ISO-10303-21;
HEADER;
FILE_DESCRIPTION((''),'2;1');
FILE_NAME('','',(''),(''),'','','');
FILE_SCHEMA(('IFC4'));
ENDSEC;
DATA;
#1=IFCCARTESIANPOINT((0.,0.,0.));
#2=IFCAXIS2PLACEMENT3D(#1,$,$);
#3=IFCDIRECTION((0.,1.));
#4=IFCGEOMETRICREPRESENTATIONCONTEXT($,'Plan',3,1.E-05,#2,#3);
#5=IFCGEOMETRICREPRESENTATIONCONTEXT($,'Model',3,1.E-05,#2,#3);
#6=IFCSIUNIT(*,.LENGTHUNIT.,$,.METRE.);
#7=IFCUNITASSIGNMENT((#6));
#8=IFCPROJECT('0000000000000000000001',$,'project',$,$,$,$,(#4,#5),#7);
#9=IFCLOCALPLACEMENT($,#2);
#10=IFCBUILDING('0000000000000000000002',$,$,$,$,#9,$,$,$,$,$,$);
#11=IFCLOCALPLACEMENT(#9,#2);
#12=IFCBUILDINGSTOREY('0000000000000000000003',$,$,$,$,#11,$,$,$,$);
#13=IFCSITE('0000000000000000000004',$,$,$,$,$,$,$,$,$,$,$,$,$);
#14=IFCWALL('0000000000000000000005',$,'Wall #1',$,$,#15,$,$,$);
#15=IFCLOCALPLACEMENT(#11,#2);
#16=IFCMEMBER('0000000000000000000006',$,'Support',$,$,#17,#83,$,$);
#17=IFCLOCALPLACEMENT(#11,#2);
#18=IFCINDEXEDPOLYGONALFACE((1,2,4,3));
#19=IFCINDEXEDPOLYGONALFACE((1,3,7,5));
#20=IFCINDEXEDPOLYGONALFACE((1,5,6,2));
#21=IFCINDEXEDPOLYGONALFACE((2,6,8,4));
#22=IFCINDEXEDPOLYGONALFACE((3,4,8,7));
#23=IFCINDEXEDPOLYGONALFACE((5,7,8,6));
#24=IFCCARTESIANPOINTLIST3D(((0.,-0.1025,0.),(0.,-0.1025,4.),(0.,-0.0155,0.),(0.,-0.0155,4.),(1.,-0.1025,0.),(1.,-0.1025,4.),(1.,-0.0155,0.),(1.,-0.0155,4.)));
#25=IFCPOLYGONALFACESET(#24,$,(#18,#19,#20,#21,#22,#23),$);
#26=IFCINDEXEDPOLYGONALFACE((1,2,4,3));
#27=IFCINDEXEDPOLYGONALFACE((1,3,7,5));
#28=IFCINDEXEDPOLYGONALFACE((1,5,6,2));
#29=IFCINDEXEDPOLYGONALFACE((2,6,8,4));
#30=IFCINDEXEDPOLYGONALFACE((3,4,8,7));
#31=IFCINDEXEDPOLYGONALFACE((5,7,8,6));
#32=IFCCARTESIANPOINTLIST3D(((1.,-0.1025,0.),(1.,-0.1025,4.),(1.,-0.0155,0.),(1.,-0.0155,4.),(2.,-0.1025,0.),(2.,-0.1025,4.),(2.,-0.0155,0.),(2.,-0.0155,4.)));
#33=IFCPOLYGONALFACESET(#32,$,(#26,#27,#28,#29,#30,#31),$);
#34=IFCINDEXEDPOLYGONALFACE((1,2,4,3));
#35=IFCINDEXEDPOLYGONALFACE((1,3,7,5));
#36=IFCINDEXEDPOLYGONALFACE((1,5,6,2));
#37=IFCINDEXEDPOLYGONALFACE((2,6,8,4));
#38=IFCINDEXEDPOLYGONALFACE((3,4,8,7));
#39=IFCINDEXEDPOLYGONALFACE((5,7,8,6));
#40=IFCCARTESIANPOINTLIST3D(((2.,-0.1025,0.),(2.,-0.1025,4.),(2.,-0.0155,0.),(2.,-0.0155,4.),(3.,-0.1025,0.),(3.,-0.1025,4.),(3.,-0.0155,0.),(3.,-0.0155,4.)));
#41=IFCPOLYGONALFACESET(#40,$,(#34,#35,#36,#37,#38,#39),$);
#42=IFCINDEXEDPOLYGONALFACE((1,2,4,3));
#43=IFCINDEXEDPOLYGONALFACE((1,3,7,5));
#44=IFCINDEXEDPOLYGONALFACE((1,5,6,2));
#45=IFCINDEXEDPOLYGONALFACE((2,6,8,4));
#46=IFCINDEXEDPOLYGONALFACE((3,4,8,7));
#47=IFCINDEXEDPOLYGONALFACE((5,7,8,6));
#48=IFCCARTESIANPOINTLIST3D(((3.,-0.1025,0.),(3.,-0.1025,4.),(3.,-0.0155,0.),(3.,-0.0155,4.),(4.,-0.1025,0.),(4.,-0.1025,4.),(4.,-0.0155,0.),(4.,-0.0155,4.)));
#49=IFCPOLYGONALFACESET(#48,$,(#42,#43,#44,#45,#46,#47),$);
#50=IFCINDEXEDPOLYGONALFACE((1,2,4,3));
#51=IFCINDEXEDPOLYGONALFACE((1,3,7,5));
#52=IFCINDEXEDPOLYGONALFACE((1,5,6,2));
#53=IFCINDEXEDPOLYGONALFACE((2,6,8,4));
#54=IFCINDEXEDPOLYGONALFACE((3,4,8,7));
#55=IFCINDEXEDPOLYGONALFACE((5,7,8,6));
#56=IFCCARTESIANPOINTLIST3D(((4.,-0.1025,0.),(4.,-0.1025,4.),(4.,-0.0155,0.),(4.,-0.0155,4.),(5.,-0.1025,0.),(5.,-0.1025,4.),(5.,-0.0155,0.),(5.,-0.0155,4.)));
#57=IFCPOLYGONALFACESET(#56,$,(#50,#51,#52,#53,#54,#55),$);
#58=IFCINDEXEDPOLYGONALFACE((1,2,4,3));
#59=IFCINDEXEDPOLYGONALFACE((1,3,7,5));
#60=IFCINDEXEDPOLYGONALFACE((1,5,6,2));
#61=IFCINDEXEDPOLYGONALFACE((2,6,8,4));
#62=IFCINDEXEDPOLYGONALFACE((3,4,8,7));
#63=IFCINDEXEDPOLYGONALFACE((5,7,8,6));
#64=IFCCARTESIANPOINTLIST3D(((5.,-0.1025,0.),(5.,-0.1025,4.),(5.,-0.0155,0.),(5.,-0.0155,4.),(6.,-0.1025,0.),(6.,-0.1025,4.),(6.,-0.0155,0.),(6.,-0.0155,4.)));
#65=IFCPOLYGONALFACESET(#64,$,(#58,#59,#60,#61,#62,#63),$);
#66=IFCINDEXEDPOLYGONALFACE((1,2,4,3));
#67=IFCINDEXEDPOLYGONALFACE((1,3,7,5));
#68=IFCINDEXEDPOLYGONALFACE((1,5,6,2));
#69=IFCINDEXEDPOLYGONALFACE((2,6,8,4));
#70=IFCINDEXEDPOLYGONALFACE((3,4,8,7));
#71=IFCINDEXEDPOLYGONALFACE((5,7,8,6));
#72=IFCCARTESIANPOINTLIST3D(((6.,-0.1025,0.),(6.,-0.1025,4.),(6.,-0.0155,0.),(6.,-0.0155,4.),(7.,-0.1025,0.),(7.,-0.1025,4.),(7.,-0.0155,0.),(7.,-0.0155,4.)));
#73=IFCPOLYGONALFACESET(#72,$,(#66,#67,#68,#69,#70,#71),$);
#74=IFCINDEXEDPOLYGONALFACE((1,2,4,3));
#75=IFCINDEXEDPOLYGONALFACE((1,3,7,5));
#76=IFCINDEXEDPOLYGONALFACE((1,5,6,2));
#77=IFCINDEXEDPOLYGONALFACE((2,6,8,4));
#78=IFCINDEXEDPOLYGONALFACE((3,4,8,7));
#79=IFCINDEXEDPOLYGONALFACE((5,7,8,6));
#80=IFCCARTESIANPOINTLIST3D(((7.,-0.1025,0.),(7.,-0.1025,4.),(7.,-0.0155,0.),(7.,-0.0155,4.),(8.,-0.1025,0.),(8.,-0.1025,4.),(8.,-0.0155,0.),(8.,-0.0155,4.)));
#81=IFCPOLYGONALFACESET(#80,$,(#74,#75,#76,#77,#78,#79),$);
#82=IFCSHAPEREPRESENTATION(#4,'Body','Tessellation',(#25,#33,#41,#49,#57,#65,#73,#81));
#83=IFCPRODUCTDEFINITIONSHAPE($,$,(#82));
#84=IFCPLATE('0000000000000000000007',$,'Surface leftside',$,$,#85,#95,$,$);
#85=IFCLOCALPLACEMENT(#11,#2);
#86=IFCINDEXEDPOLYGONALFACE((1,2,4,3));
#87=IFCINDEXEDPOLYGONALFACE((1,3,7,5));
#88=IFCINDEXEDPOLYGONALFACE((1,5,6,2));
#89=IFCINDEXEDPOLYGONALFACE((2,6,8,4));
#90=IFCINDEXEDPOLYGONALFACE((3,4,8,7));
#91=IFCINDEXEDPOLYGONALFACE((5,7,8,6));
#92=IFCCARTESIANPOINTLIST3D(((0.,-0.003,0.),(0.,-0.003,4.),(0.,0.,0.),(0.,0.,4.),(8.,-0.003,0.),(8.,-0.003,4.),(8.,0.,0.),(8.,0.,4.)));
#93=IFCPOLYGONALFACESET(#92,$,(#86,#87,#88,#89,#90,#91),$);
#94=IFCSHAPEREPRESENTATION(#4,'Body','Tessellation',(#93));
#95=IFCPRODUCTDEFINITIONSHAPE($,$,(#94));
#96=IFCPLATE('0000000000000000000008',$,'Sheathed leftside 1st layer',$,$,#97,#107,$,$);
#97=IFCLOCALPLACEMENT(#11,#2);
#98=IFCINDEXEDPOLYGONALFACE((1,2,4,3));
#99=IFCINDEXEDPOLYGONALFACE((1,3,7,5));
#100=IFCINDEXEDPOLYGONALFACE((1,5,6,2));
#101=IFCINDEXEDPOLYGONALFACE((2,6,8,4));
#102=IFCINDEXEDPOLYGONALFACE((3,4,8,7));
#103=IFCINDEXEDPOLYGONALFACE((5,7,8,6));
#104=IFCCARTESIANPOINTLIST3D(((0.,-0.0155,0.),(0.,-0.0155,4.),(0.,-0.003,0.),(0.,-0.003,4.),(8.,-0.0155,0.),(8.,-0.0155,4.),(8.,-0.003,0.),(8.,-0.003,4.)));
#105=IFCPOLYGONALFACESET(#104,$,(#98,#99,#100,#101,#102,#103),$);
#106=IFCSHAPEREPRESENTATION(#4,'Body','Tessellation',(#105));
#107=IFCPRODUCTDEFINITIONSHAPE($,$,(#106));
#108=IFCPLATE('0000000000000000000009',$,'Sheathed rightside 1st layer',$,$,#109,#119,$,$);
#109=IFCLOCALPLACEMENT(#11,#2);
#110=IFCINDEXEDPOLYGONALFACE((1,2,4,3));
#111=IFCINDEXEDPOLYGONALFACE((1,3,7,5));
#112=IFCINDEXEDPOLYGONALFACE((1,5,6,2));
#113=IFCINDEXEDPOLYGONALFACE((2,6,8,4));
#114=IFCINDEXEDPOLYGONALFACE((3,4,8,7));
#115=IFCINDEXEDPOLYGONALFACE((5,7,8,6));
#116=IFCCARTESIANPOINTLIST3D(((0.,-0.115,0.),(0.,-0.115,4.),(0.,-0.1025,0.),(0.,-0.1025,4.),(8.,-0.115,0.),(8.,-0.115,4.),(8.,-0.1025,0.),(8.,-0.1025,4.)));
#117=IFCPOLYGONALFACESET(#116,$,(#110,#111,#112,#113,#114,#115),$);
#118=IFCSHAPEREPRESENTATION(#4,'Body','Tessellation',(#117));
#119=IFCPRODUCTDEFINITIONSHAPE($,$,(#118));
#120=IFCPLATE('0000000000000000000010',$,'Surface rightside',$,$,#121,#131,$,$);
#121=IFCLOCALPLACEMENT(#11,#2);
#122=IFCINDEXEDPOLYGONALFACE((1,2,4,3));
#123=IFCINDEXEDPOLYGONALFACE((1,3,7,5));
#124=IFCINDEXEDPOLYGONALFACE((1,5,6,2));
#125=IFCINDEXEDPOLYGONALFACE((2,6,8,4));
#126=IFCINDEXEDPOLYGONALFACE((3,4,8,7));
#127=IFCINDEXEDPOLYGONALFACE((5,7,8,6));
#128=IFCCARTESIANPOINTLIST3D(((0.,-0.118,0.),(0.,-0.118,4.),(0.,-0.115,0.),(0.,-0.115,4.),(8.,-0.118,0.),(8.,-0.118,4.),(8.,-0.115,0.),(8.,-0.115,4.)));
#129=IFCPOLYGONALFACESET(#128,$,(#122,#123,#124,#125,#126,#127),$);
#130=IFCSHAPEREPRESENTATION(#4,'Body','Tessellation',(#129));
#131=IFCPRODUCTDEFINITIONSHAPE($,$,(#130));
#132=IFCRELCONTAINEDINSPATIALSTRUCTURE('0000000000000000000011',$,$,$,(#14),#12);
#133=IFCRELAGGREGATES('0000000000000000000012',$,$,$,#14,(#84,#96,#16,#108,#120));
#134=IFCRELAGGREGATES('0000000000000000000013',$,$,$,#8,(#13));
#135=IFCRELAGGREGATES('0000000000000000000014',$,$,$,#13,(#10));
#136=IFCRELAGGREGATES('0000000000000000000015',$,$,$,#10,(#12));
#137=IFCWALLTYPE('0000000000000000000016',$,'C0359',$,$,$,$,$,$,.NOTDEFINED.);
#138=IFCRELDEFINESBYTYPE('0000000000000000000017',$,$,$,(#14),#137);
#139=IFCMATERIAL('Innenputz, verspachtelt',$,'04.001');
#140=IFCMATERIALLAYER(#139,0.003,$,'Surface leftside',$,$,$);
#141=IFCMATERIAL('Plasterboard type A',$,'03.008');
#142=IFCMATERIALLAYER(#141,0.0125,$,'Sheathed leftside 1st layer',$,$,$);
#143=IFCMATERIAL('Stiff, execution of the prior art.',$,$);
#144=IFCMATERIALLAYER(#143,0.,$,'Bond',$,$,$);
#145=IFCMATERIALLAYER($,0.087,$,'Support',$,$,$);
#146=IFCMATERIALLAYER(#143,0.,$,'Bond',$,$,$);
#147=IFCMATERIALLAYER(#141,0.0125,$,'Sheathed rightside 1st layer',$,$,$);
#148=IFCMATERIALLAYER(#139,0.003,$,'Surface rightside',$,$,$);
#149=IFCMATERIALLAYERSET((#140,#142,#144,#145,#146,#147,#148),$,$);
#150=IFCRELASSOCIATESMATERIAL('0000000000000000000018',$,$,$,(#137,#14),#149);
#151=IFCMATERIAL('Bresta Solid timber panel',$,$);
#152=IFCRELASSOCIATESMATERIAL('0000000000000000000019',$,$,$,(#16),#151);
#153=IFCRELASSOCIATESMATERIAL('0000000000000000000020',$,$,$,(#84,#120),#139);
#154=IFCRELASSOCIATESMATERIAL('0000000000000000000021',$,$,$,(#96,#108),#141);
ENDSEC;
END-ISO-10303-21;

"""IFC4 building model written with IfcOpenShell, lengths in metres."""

from ifc_helpers import new_model, si_unit, direction, frame, frame_2d, origin, origin_with_axes, place, context, project, spatial, rectangle, extrude, material, layer, layer_set, type_object, element, aggregate, save


model = new_model("IFC4")

# Units and contexts
plan_context = context("Plan", 3, precision=1e-05, world=origin(), true_north=direction((0.0, 1.0)))
model_context = context("Model", 3, precision=1e-05, world=origin(), true_north=direction((0.0, 1.0)))
ifc_project = project(units=[si_unit("LENGTHUNIT", "METRE")], contexts=[plan_context, model_context])

# Site, building, storey
site = spatial("IfcSite", under=ifc_project)
building_placement = place(None, origin())
building = spatial("IfcBuilding", under=site, at=building_placement)
storey_placement = place(building_placement, origin())
storey = spatial("IfcBuildingStorey", under=building, at=storey_placement)

# Wall, member, plates
ifc_material_1 = material(Name="Innenputz, verspachtelt", Category="04.001")
ifc_layer_1 = layer(ifc_material_1, 0.003, Name="Surface leftside")
ifc_material_2 = material(Name="Plasterboard type A", Category="03.008")
ifc_layer_2 = layer(ifc_material_2, 0.0125, Name="Sheathed leftside 1st layer")
ifc_material_3 = material(Name="Stiff, execution of the prior art.")
ifc_layer_3 = layer(ifc_material_3, 0.0, Name="Bond")
ifc_layer_4 = layer(None, 0.087, Name="Support")
ifc_layer_5 = layer(ifc_material_3, 0.0, Name="Bond")
ifc_layer_6 = layer(ifc_material_2, 0.0125, Name="Sheathed rightside 1st layer")
ifc_layer_7 = layer(ifc_material_1, 0.003, Name="Surface rightside")
ifc_layer_set = layer_set([ifc_layer_1, ifc_layer_2, ifc_layer_3, ifc_layer_4, ifc_layer_5, ifc_layer_6, ifc_layer_7])
wall_type = type_object("IfcWallType", Name="C0359", PredefinedType="NOTDEFINED", material=ifc_layer_set)
wall_placement = place(None, frame((0.0, 0.0, 0.0), z_axis=(0.0, -1.0, 0.0), x_axis=(1.0, 0.0, 0.0)))
wall = element("IfcWall", 1, at=wall_placement, inside=storey, type_object=wall_type, material=ifc_layer_set, Name="Wall #1")
ifc_material_4 = material(Name="Bresta Solid timber panel")
member_placement = place(wall_placement, origin())
member = element("IfcMember", 2, at=member_placement, material=ifc_material_4, Name="Support", context=plan_context, shape_type="SweptSolid", body=[
    extrude(rectangle(XDim=1.0, YDim=0.087, at=frame_2d((0.5, 0.0435), x_axis=(1.0, 0.0))), frame((0.0, 4.0, 0.0155), z_axis=(0.0, -1.0, 0.0), x_axis=(1.0, 0.0, 0.0)), (0.0, 0.0, 1.0), 4.0),
    extrude(rectangle(XDim=1.0, YDim=0.087, at=frame_2d((0.5, 0.0435), x_axis=(1.0, 0.0))), frame((1.0, 4.0, 0.0155), z_axis=(0.0, -1.0, 0.0), x_axis=(1.0, 0.0, 0.0)), (0.0, 0.0, 1.0), 4.0),
    extrude(rectangle(XDim=1.0, YDim=0.087, at=frame_2d((0.5, 0.0435), x_axis=(1.0, 0.0))), frame((2.0, 4.0, 0.0155), z_axis=(0.0, -1.0, 0.0), x_axis=(1.0, 0.0, 0.0)), (0.0, 0.0, 1.0), 4.0),
    extrude(rectangle(XDim=1.0, YDim=0.087, at=frame_2d((0.5, 0.0435), x_axis=(1.0, 0.0))), frame((3.0, 4.0, 0.0155), z_axis=(0.0, -1.0, 0.0), x_axis=(1.0, 0.0, 0.0)), (0.0, 0.0, 1.0), 4.0),
    extrude(rectangle(XDim=1.0, YDim=0.087, at=frame_2d((0.5, 0.0435), x_axis=(1.0, 0.0))), frame((4.0, 4.0, 0.0155), z_axis=(0.0, -1.0, 0.0), x_axis=(1.0, 0.0, 0.0)), (0.0, 0.0, 1.0), 4.0),
    extrude(rectangle(XDim=1.0, YDim=0.087, at=frame_2d((0.5, 0.0435), x_axis=(1.0, 0.0))), frame((5.0, 4.0, 0.0155), z_axis=(0.0, -1.0, 0.0), x_axis=(1.0, 0.0, 0.0)), (0.0, 0.0, 1.0), 4.0),
    extrude(rectangle(XDim=1.0, YDim=0.087, at=frame_2d((0.5, 0.0435), x_axis=(1.0, 0.0))), frame((6.0, 4.0, 0.0155), z_axis=(0.0, -1.0, 0.0), x_axis=(1.0, 0.0, 0.0)), (0.0, 0.0, 1.0), 4.0),
    extrude(rectangle(XDim=1.0, YDim=0.087, at=frame_2d((0.5, 0.0435), x_axis=(1.0, 0.0))), frame((7.0, 4.0, 0.0155), z_axis=(0.0, -1.0, 0.0), x_axis=(1.0, 0.0, 0.0)), (0.0, 0.0, 1.0), 4.0),
])
plate_1_placement = place(wall_placement, origin())
plate_1 = element("IfcPlate", 3, at=plate_1_placement, material=ifc_material_1, Name="Surface leftside", context=plan_context, shape_type="SweptSolid", body=[
    extrude(rectangle(XDim=8.0, YDim=4.0, at=frame_2d((4.0, 2.0), x_axis=(1.0, 0.0))), origin_with_axes(), (0.0, 0.0, 1.0), 0.003),
])
plate_2_placement = place(wall_placement, origin())
plate_2 = element("IfcPlate", 4, at=plate_2_placement, material=ifc_material_2, Name="Sheathed leftside 1st layer", context=plan_context, shape_type="SweptSolid", body=[
    extrude(rectangle(XDim=8.0, YDim=4.0, at=frame_2d((4.0, 2.0), x_axis=(1.0, 0.0))), frame((0.0, 0.0, 0.003), z_axis=(0.0, 0.0, 1.0), x_axis=(1.0, 0.0, 0.0)), (0.0, 0.0, 1.0), 0.0125),
])
plate_3_placement = place(wall_placement, origin())
plate_3 = element("IfcPlate", 5, at=plate_3_placement, material=ifc_material_2, Name="Sheathed rightside 1st layer", context=plan_context, shape_type="SweptSolid", body=[
    extrude(rectangle(XDim=8.0, YDim=4.0, at=frame_2d((4.0, 2.0), x_axis=(1.0, 0.0))), frame((0.0, 0.0, 0.1025), z_axis=(0.0, 0.0, 1.0), x_axis=(1.0, 0.0, 0.0)), (0.0, 0.0, 1.0), 0.0125),
])
plate_4_placement = place(wall_placement, origin())
plate_4 = element("IfcPlate", 6, at=plate_4_placement, material=ifc_material_1, Name="Surface rightside", context=plan_context, shape_type="SweptSolid", body=[
    extrude(rectangle(XDim=8.0, YDim=4.0, at=frame_2d((4.0, 2.0), x_axis=(1.0, 0.0))), frame((0.0, 0.0, 0.115), z_axis=(0.0, 0.0, 1.0), x_axis=(1.0, 0.0, 0.0)), (0.0, 0.0, 1.0), 0.003),
])
aggregate(wall, [plate_1, plate_2, member, plate_3, plate_4])

save(model, "model.ifc")
